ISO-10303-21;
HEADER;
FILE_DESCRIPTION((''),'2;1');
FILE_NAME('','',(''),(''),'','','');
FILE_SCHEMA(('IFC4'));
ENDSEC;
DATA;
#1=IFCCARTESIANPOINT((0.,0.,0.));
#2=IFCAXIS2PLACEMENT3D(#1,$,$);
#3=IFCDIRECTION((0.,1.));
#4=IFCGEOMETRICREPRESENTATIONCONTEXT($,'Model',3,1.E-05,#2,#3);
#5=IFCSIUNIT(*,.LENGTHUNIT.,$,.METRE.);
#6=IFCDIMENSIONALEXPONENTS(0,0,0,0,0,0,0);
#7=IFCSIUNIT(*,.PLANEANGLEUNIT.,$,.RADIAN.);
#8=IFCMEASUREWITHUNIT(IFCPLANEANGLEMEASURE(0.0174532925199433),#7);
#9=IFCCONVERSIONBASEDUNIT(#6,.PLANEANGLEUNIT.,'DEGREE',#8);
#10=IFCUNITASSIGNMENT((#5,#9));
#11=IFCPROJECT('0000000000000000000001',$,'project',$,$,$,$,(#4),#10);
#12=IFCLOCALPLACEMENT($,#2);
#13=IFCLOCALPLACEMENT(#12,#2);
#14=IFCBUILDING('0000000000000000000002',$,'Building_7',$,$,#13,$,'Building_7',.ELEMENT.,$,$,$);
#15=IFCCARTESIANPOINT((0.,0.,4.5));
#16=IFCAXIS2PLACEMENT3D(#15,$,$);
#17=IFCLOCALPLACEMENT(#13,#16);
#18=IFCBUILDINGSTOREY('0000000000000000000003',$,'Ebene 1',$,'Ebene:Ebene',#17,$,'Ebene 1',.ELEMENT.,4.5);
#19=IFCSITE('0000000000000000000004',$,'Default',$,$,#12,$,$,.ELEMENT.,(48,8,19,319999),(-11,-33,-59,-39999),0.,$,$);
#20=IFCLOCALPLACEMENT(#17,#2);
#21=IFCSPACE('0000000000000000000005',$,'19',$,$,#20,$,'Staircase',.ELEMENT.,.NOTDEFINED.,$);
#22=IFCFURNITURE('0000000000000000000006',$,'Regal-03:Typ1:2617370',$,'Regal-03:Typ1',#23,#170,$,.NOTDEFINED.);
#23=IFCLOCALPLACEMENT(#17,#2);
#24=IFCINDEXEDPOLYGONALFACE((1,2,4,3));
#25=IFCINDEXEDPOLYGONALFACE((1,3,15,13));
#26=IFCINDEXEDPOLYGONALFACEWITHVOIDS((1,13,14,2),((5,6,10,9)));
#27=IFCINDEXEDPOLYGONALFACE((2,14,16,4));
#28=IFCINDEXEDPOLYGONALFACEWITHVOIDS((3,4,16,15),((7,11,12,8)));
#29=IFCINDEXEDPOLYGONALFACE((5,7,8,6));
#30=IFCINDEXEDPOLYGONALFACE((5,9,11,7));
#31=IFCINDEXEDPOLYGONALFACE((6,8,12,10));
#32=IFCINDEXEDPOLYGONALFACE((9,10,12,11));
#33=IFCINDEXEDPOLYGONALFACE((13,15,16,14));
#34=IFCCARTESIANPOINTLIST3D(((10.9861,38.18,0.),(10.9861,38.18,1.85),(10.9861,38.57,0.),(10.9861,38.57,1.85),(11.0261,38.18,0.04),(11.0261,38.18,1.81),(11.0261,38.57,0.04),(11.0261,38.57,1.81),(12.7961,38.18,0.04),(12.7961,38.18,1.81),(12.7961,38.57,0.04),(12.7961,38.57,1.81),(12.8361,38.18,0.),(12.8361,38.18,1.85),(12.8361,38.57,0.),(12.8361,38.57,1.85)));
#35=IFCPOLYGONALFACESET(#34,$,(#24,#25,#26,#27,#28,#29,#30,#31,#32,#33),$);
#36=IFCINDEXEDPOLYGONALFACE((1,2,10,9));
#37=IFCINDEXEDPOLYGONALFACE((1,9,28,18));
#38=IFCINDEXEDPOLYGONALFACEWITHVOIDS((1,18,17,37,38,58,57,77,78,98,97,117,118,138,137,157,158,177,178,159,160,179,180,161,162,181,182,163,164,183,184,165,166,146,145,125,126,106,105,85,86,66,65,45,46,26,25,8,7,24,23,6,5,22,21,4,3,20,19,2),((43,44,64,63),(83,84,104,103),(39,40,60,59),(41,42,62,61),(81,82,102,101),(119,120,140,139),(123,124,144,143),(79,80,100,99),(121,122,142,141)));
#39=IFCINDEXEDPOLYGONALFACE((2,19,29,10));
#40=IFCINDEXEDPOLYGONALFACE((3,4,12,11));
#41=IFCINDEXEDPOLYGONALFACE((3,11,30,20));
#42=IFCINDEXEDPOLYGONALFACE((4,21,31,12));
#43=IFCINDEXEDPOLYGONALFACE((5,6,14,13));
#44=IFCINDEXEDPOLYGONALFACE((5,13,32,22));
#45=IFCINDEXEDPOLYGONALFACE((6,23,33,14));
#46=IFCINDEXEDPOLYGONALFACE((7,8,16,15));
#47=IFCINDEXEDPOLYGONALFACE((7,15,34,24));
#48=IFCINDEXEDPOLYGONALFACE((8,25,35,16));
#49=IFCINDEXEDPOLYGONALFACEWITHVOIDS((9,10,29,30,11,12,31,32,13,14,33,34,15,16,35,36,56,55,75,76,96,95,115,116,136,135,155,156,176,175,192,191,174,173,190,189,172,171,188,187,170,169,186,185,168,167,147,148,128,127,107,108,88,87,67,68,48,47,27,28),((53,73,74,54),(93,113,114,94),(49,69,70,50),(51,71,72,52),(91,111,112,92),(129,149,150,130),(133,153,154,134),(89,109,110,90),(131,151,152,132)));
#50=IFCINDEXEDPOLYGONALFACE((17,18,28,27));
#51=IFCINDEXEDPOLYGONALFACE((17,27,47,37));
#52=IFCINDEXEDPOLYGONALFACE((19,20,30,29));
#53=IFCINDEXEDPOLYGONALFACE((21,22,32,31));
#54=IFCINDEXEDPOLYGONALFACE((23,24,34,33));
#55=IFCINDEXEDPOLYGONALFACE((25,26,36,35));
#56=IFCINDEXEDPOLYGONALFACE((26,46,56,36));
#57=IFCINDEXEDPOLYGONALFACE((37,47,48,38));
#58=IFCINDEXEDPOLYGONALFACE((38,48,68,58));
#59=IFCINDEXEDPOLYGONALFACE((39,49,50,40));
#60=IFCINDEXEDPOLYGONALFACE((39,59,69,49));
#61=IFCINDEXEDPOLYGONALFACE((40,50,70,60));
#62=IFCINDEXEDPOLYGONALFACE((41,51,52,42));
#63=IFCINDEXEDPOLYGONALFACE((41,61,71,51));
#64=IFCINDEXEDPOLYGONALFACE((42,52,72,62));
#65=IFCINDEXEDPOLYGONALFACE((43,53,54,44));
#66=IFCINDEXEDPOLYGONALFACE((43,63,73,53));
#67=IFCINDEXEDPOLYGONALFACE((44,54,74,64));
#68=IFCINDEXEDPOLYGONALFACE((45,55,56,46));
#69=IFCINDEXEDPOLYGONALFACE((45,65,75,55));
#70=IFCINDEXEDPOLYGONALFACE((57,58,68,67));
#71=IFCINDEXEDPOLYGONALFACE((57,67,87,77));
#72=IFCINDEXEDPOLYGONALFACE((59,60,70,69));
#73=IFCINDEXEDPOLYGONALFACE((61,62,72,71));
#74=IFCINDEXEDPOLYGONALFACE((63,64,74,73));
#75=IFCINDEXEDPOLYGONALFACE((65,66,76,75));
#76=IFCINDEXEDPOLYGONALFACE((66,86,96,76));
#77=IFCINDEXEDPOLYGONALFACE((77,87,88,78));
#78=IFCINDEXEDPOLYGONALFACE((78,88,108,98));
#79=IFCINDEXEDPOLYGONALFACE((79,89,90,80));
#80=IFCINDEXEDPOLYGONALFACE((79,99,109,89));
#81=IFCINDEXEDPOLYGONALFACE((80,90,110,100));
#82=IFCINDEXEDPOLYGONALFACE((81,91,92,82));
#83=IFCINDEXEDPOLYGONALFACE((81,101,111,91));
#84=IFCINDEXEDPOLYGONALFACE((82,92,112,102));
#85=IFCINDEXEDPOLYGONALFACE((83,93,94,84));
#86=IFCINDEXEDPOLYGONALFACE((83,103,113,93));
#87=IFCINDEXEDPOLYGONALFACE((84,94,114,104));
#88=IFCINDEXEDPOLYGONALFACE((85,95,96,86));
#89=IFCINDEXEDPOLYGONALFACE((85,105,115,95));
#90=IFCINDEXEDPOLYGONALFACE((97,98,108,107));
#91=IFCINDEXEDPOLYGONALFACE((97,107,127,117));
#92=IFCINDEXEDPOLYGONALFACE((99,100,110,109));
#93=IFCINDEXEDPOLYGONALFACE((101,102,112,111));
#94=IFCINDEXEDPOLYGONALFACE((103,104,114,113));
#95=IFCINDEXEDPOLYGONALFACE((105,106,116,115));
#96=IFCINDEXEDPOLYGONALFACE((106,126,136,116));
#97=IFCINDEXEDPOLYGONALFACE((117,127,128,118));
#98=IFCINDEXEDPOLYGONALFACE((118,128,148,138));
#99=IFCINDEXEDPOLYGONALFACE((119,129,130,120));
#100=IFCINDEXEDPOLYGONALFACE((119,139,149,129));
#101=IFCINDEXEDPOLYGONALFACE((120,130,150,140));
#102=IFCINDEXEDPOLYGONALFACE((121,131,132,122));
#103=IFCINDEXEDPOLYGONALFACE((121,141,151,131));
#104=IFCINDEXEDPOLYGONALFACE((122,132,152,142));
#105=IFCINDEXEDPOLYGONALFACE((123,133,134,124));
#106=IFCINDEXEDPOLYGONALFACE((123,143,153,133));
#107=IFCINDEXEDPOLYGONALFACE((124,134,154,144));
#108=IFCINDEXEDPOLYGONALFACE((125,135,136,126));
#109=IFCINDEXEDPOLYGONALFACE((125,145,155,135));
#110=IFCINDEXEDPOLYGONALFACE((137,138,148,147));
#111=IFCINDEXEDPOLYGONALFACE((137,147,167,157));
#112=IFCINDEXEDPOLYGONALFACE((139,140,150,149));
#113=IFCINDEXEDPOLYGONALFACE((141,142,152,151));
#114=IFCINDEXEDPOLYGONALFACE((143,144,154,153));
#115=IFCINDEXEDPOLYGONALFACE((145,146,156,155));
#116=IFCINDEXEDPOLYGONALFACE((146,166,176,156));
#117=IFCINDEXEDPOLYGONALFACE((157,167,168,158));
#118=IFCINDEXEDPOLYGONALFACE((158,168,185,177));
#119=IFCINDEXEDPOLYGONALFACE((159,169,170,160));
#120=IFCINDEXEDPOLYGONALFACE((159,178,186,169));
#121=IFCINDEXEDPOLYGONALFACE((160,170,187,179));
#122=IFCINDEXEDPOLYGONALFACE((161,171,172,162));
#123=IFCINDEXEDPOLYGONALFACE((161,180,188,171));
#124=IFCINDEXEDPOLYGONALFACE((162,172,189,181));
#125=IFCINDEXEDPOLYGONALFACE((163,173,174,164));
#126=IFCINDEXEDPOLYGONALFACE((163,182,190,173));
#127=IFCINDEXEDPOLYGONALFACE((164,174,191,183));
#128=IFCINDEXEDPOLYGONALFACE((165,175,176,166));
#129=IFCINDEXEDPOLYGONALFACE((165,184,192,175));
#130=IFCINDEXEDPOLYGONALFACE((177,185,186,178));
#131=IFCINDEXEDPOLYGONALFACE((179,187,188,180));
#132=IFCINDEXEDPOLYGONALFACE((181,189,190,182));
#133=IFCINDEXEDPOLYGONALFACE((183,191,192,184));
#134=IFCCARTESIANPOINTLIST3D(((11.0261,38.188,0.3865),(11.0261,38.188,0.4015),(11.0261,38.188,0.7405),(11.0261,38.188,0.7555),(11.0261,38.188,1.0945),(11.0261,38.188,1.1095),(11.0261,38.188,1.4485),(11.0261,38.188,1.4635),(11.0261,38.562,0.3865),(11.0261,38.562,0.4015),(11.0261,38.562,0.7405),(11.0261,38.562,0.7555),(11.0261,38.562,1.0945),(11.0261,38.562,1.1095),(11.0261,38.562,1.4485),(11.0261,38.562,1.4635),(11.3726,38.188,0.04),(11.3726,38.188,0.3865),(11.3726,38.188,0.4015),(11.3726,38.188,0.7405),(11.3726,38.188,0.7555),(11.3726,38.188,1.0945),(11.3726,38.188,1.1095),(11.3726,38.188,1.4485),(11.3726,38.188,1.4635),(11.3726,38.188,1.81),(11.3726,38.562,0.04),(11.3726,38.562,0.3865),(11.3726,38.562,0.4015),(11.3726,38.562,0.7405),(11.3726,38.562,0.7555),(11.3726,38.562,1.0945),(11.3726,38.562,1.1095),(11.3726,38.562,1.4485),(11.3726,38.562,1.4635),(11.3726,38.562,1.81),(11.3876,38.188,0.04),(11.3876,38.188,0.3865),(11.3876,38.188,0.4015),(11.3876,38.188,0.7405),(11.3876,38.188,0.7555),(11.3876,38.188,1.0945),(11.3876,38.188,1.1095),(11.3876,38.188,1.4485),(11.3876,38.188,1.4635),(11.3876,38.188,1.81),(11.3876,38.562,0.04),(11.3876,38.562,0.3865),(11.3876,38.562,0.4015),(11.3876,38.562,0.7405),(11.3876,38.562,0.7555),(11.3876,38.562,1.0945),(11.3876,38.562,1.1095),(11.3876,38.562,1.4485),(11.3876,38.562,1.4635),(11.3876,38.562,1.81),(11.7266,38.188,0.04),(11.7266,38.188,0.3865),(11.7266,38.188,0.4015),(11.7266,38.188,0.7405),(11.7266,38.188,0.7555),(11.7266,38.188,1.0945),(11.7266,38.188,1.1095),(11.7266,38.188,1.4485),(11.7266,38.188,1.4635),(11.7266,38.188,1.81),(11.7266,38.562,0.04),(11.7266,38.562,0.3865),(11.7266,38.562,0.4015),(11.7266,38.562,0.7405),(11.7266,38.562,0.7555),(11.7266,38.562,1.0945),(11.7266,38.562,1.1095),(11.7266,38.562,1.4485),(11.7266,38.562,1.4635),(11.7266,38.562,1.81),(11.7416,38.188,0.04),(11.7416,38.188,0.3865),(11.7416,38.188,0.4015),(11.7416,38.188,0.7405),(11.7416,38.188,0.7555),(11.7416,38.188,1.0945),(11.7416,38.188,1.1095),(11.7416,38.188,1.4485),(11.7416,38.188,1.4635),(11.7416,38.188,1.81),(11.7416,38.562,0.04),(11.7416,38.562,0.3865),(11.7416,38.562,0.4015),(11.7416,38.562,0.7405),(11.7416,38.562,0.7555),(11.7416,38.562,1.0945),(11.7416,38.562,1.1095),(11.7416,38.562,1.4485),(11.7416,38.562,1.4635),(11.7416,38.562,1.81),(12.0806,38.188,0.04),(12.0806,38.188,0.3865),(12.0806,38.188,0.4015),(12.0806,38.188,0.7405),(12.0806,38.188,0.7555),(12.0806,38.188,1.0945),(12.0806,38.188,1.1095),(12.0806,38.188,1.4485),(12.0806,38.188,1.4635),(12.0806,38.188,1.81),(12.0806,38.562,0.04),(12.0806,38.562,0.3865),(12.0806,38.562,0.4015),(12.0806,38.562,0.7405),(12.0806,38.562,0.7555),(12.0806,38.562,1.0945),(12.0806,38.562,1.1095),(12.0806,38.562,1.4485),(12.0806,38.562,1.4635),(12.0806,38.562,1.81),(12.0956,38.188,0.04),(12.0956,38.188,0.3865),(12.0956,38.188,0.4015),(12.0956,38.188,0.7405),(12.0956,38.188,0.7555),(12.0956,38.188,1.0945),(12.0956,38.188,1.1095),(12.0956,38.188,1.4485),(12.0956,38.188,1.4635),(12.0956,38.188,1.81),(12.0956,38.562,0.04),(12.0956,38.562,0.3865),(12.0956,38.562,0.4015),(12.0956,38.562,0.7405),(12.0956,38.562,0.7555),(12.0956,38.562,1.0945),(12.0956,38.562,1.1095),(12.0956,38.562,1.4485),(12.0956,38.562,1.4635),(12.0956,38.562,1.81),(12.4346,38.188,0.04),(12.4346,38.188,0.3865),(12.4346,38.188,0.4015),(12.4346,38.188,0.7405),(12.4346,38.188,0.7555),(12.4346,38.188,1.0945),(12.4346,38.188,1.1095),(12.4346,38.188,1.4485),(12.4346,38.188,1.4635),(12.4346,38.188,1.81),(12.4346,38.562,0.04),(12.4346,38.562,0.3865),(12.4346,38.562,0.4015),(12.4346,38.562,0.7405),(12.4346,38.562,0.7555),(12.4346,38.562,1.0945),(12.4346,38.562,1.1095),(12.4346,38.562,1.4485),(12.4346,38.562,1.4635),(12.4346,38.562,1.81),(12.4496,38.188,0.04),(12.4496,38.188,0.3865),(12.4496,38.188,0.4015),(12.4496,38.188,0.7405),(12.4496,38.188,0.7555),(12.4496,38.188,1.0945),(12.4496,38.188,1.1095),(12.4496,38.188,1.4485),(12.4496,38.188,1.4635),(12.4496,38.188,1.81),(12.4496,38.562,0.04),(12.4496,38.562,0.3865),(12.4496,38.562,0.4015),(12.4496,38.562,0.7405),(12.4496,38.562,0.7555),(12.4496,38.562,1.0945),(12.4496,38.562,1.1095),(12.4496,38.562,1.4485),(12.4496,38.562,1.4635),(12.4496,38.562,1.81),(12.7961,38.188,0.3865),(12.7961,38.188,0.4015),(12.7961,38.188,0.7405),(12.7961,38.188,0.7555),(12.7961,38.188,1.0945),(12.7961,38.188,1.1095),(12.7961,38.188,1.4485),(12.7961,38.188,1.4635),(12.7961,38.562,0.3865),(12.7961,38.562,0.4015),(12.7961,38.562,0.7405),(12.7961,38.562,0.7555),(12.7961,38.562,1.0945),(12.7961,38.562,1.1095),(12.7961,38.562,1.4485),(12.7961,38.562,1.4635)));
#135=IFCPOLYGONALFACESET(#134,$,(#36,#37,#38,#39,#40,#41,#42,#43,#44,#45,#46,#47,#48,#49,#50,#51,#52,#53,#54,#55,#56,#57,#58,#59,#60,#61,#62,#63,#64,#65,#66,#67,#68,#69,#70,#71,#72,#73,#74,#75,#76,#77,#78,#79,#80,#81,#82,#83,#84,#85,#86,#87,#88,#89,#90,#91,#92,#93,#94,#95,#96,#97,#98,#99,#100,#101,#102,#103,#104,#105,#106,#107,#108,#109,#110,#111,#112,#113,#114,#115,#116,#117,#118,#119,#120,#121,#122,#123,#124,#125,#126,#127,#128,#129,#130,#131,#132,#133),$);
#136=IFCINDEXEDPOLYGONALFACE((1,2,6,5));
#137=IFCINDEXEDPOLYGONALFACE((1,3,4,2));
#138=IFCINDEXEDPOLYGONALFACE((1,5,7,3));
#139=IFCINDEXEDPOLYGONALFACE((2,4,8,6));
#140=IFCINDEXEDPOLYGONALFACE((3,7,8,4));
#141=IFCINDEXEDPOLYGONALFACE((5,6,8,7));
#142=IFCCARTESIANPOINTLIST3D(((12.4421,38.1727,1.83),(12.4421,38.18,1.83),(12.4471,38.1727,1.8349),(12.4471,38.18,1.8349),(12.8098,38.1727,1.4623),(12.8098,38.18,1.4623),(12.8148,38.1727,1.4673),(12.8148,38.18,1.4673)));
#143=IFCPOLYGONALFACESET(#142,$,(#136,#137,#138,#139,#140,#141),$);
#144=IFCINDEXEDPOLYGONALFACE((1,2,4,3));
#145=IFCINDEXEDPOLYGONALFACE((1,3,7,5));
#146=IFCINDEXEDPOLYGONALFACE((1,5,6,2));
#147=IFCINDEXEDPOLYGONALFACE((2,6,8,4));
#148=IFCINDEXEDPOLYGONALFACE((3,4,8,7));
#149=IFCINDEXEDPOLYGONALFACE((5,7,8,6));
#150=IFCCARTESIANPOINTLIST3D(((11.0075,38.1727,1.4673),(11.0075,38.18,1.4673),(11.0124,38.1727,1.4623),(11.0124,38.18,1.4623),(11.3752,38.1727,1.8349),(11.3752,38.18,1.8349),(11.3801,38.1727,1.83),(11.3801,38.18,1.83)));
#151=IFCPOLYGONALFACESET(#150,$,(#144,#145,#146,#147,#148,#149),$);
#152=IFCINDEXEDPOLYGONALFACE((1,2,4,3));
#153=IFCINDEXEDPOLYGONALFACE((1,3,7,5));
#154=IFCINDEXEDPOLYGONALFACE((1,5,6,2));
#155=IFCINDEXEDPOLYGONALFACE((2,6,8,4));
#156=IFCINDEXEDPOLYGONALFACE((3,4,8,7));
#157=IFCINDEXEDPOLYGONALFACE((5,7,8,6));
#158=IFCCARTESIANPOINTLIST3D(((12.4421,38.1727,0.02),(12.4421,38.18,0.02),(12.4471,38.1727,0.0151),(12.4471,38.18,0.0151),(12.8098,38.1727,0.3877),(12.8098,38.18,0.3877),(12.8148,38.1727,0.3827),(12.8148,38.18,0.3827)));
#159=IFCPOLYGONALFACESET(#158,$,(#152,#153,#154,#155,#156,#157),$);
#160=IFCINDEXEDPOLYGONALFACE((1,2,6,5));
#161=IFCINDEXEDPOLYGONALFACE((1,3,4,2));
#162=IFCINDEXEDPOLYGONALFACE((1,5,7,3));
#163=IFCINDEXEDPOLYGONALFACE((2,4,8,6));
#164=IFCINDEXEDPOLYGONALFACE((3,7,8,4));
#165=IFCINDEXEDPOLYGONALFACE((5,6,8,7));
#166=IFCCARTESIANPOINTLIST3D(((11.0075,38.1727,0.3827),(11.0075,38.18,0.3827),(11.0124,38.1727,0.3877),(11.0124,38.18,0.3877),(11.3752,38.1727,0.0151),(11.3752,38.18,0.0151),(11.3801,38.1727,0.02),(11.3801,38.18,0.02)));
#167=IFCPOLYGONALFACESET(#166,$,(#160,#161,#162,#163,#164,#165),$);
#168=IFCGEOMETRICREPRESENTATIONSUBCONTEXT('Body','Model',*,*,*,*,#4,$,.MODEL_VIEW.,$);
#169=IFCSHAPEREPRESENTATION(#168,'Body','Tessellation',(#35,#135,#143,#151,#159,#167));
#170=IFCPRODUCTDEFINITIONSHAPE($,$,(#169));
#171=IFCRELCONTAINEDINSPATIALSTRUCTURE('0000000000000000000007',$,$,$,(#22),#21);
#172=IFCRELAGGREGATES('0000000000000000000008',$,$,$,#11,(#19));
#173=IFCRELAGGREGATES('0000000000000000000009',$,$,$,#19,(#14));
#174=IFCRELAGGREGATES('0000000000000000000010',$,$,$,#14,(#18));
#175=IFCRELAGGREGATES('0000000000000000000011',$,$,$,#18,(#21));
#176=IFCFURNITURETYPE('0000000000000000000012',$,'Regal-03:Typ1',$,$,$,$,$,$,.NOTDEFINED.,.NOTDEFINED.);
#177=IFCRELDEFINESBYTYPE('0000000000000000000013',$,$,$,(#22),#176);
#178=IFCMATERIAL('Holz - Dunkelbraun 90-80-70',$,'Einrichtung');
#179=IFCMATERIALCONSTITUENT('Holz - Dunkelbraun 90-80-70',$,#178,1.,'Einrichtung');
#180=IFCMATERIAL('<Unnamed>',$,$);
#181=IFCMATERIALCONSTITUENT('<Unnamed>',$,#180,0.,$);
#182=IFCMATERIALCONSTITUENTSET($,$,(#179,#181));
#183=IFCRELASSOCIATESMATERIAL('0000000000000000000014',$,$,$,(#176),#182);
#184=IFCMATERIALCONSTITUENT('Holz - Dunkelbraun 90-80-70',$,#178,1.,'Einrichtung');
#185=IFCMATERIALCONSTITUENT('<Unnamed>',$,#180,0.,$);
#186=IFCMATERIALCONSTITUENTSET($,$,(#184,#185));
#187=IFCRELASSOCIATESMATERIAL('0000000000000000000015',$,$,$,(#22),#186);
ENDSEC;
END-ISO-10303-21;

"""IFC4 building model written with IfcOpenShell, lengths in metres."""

from ifc_helpers import new_model, entity, si_unit, converted_unit, direction, frame, origin, place, context, subcontext, project, spatial, indexed_curve, outline, extrude, source, transform, mapped, material, constituent, constituent_set, type_object, type_shapes, element, save


model = new_model("IFC4")

# Units and contexts
model_context = context("Model", 3, precision=1e-05, world=origin(), true_north=direction((0.0, 1.0)))
body_context = subcontext(model_context, "Body", "Model", "MODEL_VIEW")
ifc_project = project(units=[si_unit("LENGTHUNIT", "METRE"), converted_unit("PLANEANGLEUNIT", "DEGREE", entity("IfcPlaneAngleMeasure", 0.0174532925199433), si_unit("PLANEANGLEUNIT", "RADIAN"), dimensions=[0, 0, 0, 0, 0, 0, 0])], contexts=[model_context])

# Site, building, storey
site_placement = place(None, origin())
site = spatial("IfcSite", under=ifc_project, at=site_placement, Name="Default", CompositionType="ELEMENT", RefLatitude=(48, 8, 19, 319999), RefLongitude=(-11, -33, -59, -39999), RefElevation=0.0)
building_placement = place(site_placement, origin())
building = spatial("IfcBuilding", under=site, at=building_placement, Name="Building_7", LongName="Building_7", CompositionType="ELEMENT")
storey_placement = place(building_placement, frame((0.0, 0.0, 4.5)))
storey = spatial("IfcBuildingStorey", under=building, at=storey_placement, Name="Ebene 1", ObjectType="Ebene:Ebene", LongName="Ebene 1", CompositionType="ELEMENT", Elevation=4.5)

# Shared definitions
ifc_material_1 = material(Name="<Unnamed>")

# Shared definitions
ifc_material_2 = material(Name="Holz - Dunkelbraun 90-80-70", Category="Einrichtung")

# Shared definitions
space_1_placement = place(storey_placement, origin())
space_1 = spatial("IfcSpace", under=storey, at=space_1_placement, Name="19", LongName="Staircase", CompositionType="ELEMENT", PredefinedType="NOTDEFINED")

# Furniture
ifc_constituent_1 = constituent(ifc_material_2, Name="Holz - Dunkelbraun 90-80-70", Category="Einrichtung", fraction=1.0)
ifc_constituent_2 = constituent(ifc_material_1, Name="<Unnamed>", fraction=0.0)
ifc_constituent_set_1 = constituent_set(constituents=[ifc_constituent_1, ifc_constituent_2])
furniture_type_1 = type_object("IfcFurnitureType", Name="Regal-03:Typ1", AssemblyPlace="NOTDEFINED", PredefinedType="NOTDEFINED", material=ifc_constituent_set_1)
shared_shape_1 = source(origin(), body_context, "Body", "SweptSolid", [
    extrude(outline(indexed_curve([(-0.925, -0.925), (0.925, -0.925), (0.925, 0.925), (-0.925, 0.925), (-0.925, -0.925)], self_intersect=False), holes=[indexed_curve([(-0.885, -0.885), (-0.885, 0.885), (0.885, 0.885), (0.885, -0.885), (-0.885, -0.885)], self_intersect=False)]), frame((0.2471, -0.1249, 0.925), z_axis=(0.0, 1.0, 0.0), x_axis=(0.0, 0.0, -1.0)), (0.0, 0.0, 1.0), 0.39),
    extrude(outline(indexed_curve([(0.5385, -0.5385), (0.885, -0.5385), (0.885, -0.5235), (0.5385, -0.5235), (0.5385, -0.1845), (0.885, -0.1845), (0.885, -0.1695), (0.5385, -0.1695), (0.5385, 0.1695), (0.885, 0.1695), (0.885, 0.1845), (0.5385, 0.1845), (0.5385, 0.5235), (0.885, 0.5235), (0.885, 0.5385), (0.5385, 0.5385), (0.5385, 0.885), (0.5235, 0.885), (0.5235, 0.5385), (0.1845, 0.5385), (0.1845, 0.885), (0.1695, 0.885), (0.1695, 0.5385), (-0.1695, 0.5385), (-0.1695, 0.885), (-0.1845, 0.885), (-0.1845, 0.5385), (-0.5235, 0.5385), (-0.5235, 0.885), (-0.5385, 0.885), (-0.5385, 0.5385), (-0.885, 0.5385), (-0.885, 0.5235), (-0.5385, 0.5235), (-0.5385, 0.1845), (-0.885, 0.1845), (-0.885, 0.1695), (-0.5385, 0.1695), (-0.5385, -0.1695), (-0.885, -0.1695), (-0.885, -0.1845), (-0.5385, -0.1845), (-0.5385, -0.5235), (-0.885, -0.5235), (-0.885, -0.5385), (-0.5385, -0.5385), (-0.5385, -0.885), (-0.5235, -0.885), (-0.5235, -0.5385), (-0.1845, -0.5385), (-0.1845, -0.885), (-0.1695, -0.885), (-0.1695, -0.5385), (0.1695, -0.5385), (0.1695, -0.885), (0.1845, -0.885), (0.1845, -0.5385), (0.5235, -0.5385), (0.5235, -0.885), (0.5385, -0.885), (0.5385, -0.5385)], self_intersect=False), holes=[indexed_curve([(0.5235, -0.1845), (0.5235, -0.5235), (0.1845, -0.5235), (0.1845, -0.1845), (0.5235, -0.1845)], self_intersect=False), indexed_curve([(0.1845, -0.1695), (0.1845, 0.1695), (0.5235, 0.1695), (0.5235, -0.1695), (0.1845, -0.1695)], self_intersect=False), indexed_curve([(0.1845, 0.1845), (0.1845, 0.5235), (0.5235, 0.5235), (0.5235, 0.1845), (0.1845, 0.1845)], self_intersect=False), indexed_curve([(-0.1695, 0.5235), (0.1695, 0.5235), (0.1695, 0.1845), (-0.1695, 0.1845), (-0.1695, 0.5235)], self_intersect=False), indexed_curve([(-0.1695, 0.1695), (0.1695, 0.1695), (0.1695, -0.1695), (-0.1695, -0.1695), (-0.1695, 0.1695)], self_intersect=False), indexed_curve([(-0.1695, -0.1845), (0.1695, -0.1845), (0.1695, -0.5235), (-0.1695, -0.5235), (-0.1695, -0.1845)], self_intersect=False), indexed_curve([(-0.5235, -0.5235), (-0.5235, -0.1845), (-0.1845, -0.1845), (-0.1845, -0.5235), (-0.5235, -0.5235)], self_intersect=False), indexed_curve([(-0.5235, -0.1695), (-0.5235, 0.1695), (-0.1845, 0.1695), (-0.1845, -0.1695), (-0.5235, -0.1695)], self_intersect=False), indexed_curve([(-0.5235, 0.1845), (-0.5235, 0.5235), (-0.1845, 0.5235), (-0.1845, 0.1845), (-0.5235, 0.1845)], self_intersect=False)]), frame((0.2471, -0.1169, 0.925), z_axis=(0.0, 1.0, 0.0), x_axis=(0.0, 0.0, 1.0)), (0.0, 0.0, 1.0), 0.374),
    extrude(outline(indexed_curve([(-0.0035, -0.0037), (0.0035, -0.0037), (0.0035, 0.0037), (-0.0035, 0.0037), (-0.0035, -0.0037)], self_intersect=False)), frame((1.1482, -0.1286, 1.4648), z_axis=(-0.707107, 0.0, 0.707107), x_axis=(-0.707107, 0.0, -0.707107)), (0.0, 0.0, 1.0), 0.52),
    extrude(outline(indexed_curve([(-0.0035, -0.0037), (0.0035, -0.0037), (0.0035, 0.0037), (-0.0035, 0.0037), (-0.0035, -0.0037)], self_intersect=False)), frame((-0.6541, -0.1286, 1.4648), z_axis=(0.707107, 0.0, 0.707107), x_axis=(-0.707107, 0.0, 0.707107)), (0.0, 0.0, 1.0), 0.52),
    extrude(outline(indexed_curve([(-0.0035, -0.0037), (0.0035, -0.0037), (0.0035, 0.0037), (-0.0035, 0.0037), (-0.0035, -0.0037)], self_intersect=False)), frame((0.7805, -0.1286, 0.0175), z_axis=(0.707107, 0.0, 0.707107), x_axis=(-0.707107, 0.0, 0.707107)), (0.0, 0.0, 1.0), 0.52),
    extrude(outline(indexed_curve([(-0.0035, -0.0037), (0.0035, -0.0037), (0.0035, 0.0037), (-0.0035, 0.0037), (-0.0035, -0.0037)], self_intersect=False)), frame((-0.2864, -0.1286, 0.0175), z_axis=(-0.707107, 0.0, 0.707107), x_axis=(-0.707107, 0.0, -0.707107)), (0.0, 0.0, 1.0), 0.52),
])
type_shapes(furniture_type_1, [shared_shape_1])
ifc_constituent_3 = constituent(ifc_material_2, Name="Holz - Dunkelbraun 90-80-70", Category="Einrichtung", fraction=1.0)
ifc_constituent_4 = constituent(ifc_material_1, Name="<Unnamed>", fraction=0.0)
ifc_constituent_set_2 = constituent_set(constituents=[ifc_constituent_3, ifc_constituent_4])
furniture_1_placement = place(space_1_placement, frame((11.6641, 38.3049, 0.0)))
element("IfcFurniture", 1, at=furniture_1_placement, inside=space_1, type_object=furniture_type_1, material=ifc_constituent_set_2, Name="Regal-03:Typ1:2617370", ObjectType="Regal-03:Typ1", PredefinedType="NOTDEFINED", context=body_context, shape_type="MappedRepresentation", body=[
    mapped(shared_shape_1, transform((0.0, 0.0, 0.0), scale=1.0)),
])

save(model, "model.ifc")
